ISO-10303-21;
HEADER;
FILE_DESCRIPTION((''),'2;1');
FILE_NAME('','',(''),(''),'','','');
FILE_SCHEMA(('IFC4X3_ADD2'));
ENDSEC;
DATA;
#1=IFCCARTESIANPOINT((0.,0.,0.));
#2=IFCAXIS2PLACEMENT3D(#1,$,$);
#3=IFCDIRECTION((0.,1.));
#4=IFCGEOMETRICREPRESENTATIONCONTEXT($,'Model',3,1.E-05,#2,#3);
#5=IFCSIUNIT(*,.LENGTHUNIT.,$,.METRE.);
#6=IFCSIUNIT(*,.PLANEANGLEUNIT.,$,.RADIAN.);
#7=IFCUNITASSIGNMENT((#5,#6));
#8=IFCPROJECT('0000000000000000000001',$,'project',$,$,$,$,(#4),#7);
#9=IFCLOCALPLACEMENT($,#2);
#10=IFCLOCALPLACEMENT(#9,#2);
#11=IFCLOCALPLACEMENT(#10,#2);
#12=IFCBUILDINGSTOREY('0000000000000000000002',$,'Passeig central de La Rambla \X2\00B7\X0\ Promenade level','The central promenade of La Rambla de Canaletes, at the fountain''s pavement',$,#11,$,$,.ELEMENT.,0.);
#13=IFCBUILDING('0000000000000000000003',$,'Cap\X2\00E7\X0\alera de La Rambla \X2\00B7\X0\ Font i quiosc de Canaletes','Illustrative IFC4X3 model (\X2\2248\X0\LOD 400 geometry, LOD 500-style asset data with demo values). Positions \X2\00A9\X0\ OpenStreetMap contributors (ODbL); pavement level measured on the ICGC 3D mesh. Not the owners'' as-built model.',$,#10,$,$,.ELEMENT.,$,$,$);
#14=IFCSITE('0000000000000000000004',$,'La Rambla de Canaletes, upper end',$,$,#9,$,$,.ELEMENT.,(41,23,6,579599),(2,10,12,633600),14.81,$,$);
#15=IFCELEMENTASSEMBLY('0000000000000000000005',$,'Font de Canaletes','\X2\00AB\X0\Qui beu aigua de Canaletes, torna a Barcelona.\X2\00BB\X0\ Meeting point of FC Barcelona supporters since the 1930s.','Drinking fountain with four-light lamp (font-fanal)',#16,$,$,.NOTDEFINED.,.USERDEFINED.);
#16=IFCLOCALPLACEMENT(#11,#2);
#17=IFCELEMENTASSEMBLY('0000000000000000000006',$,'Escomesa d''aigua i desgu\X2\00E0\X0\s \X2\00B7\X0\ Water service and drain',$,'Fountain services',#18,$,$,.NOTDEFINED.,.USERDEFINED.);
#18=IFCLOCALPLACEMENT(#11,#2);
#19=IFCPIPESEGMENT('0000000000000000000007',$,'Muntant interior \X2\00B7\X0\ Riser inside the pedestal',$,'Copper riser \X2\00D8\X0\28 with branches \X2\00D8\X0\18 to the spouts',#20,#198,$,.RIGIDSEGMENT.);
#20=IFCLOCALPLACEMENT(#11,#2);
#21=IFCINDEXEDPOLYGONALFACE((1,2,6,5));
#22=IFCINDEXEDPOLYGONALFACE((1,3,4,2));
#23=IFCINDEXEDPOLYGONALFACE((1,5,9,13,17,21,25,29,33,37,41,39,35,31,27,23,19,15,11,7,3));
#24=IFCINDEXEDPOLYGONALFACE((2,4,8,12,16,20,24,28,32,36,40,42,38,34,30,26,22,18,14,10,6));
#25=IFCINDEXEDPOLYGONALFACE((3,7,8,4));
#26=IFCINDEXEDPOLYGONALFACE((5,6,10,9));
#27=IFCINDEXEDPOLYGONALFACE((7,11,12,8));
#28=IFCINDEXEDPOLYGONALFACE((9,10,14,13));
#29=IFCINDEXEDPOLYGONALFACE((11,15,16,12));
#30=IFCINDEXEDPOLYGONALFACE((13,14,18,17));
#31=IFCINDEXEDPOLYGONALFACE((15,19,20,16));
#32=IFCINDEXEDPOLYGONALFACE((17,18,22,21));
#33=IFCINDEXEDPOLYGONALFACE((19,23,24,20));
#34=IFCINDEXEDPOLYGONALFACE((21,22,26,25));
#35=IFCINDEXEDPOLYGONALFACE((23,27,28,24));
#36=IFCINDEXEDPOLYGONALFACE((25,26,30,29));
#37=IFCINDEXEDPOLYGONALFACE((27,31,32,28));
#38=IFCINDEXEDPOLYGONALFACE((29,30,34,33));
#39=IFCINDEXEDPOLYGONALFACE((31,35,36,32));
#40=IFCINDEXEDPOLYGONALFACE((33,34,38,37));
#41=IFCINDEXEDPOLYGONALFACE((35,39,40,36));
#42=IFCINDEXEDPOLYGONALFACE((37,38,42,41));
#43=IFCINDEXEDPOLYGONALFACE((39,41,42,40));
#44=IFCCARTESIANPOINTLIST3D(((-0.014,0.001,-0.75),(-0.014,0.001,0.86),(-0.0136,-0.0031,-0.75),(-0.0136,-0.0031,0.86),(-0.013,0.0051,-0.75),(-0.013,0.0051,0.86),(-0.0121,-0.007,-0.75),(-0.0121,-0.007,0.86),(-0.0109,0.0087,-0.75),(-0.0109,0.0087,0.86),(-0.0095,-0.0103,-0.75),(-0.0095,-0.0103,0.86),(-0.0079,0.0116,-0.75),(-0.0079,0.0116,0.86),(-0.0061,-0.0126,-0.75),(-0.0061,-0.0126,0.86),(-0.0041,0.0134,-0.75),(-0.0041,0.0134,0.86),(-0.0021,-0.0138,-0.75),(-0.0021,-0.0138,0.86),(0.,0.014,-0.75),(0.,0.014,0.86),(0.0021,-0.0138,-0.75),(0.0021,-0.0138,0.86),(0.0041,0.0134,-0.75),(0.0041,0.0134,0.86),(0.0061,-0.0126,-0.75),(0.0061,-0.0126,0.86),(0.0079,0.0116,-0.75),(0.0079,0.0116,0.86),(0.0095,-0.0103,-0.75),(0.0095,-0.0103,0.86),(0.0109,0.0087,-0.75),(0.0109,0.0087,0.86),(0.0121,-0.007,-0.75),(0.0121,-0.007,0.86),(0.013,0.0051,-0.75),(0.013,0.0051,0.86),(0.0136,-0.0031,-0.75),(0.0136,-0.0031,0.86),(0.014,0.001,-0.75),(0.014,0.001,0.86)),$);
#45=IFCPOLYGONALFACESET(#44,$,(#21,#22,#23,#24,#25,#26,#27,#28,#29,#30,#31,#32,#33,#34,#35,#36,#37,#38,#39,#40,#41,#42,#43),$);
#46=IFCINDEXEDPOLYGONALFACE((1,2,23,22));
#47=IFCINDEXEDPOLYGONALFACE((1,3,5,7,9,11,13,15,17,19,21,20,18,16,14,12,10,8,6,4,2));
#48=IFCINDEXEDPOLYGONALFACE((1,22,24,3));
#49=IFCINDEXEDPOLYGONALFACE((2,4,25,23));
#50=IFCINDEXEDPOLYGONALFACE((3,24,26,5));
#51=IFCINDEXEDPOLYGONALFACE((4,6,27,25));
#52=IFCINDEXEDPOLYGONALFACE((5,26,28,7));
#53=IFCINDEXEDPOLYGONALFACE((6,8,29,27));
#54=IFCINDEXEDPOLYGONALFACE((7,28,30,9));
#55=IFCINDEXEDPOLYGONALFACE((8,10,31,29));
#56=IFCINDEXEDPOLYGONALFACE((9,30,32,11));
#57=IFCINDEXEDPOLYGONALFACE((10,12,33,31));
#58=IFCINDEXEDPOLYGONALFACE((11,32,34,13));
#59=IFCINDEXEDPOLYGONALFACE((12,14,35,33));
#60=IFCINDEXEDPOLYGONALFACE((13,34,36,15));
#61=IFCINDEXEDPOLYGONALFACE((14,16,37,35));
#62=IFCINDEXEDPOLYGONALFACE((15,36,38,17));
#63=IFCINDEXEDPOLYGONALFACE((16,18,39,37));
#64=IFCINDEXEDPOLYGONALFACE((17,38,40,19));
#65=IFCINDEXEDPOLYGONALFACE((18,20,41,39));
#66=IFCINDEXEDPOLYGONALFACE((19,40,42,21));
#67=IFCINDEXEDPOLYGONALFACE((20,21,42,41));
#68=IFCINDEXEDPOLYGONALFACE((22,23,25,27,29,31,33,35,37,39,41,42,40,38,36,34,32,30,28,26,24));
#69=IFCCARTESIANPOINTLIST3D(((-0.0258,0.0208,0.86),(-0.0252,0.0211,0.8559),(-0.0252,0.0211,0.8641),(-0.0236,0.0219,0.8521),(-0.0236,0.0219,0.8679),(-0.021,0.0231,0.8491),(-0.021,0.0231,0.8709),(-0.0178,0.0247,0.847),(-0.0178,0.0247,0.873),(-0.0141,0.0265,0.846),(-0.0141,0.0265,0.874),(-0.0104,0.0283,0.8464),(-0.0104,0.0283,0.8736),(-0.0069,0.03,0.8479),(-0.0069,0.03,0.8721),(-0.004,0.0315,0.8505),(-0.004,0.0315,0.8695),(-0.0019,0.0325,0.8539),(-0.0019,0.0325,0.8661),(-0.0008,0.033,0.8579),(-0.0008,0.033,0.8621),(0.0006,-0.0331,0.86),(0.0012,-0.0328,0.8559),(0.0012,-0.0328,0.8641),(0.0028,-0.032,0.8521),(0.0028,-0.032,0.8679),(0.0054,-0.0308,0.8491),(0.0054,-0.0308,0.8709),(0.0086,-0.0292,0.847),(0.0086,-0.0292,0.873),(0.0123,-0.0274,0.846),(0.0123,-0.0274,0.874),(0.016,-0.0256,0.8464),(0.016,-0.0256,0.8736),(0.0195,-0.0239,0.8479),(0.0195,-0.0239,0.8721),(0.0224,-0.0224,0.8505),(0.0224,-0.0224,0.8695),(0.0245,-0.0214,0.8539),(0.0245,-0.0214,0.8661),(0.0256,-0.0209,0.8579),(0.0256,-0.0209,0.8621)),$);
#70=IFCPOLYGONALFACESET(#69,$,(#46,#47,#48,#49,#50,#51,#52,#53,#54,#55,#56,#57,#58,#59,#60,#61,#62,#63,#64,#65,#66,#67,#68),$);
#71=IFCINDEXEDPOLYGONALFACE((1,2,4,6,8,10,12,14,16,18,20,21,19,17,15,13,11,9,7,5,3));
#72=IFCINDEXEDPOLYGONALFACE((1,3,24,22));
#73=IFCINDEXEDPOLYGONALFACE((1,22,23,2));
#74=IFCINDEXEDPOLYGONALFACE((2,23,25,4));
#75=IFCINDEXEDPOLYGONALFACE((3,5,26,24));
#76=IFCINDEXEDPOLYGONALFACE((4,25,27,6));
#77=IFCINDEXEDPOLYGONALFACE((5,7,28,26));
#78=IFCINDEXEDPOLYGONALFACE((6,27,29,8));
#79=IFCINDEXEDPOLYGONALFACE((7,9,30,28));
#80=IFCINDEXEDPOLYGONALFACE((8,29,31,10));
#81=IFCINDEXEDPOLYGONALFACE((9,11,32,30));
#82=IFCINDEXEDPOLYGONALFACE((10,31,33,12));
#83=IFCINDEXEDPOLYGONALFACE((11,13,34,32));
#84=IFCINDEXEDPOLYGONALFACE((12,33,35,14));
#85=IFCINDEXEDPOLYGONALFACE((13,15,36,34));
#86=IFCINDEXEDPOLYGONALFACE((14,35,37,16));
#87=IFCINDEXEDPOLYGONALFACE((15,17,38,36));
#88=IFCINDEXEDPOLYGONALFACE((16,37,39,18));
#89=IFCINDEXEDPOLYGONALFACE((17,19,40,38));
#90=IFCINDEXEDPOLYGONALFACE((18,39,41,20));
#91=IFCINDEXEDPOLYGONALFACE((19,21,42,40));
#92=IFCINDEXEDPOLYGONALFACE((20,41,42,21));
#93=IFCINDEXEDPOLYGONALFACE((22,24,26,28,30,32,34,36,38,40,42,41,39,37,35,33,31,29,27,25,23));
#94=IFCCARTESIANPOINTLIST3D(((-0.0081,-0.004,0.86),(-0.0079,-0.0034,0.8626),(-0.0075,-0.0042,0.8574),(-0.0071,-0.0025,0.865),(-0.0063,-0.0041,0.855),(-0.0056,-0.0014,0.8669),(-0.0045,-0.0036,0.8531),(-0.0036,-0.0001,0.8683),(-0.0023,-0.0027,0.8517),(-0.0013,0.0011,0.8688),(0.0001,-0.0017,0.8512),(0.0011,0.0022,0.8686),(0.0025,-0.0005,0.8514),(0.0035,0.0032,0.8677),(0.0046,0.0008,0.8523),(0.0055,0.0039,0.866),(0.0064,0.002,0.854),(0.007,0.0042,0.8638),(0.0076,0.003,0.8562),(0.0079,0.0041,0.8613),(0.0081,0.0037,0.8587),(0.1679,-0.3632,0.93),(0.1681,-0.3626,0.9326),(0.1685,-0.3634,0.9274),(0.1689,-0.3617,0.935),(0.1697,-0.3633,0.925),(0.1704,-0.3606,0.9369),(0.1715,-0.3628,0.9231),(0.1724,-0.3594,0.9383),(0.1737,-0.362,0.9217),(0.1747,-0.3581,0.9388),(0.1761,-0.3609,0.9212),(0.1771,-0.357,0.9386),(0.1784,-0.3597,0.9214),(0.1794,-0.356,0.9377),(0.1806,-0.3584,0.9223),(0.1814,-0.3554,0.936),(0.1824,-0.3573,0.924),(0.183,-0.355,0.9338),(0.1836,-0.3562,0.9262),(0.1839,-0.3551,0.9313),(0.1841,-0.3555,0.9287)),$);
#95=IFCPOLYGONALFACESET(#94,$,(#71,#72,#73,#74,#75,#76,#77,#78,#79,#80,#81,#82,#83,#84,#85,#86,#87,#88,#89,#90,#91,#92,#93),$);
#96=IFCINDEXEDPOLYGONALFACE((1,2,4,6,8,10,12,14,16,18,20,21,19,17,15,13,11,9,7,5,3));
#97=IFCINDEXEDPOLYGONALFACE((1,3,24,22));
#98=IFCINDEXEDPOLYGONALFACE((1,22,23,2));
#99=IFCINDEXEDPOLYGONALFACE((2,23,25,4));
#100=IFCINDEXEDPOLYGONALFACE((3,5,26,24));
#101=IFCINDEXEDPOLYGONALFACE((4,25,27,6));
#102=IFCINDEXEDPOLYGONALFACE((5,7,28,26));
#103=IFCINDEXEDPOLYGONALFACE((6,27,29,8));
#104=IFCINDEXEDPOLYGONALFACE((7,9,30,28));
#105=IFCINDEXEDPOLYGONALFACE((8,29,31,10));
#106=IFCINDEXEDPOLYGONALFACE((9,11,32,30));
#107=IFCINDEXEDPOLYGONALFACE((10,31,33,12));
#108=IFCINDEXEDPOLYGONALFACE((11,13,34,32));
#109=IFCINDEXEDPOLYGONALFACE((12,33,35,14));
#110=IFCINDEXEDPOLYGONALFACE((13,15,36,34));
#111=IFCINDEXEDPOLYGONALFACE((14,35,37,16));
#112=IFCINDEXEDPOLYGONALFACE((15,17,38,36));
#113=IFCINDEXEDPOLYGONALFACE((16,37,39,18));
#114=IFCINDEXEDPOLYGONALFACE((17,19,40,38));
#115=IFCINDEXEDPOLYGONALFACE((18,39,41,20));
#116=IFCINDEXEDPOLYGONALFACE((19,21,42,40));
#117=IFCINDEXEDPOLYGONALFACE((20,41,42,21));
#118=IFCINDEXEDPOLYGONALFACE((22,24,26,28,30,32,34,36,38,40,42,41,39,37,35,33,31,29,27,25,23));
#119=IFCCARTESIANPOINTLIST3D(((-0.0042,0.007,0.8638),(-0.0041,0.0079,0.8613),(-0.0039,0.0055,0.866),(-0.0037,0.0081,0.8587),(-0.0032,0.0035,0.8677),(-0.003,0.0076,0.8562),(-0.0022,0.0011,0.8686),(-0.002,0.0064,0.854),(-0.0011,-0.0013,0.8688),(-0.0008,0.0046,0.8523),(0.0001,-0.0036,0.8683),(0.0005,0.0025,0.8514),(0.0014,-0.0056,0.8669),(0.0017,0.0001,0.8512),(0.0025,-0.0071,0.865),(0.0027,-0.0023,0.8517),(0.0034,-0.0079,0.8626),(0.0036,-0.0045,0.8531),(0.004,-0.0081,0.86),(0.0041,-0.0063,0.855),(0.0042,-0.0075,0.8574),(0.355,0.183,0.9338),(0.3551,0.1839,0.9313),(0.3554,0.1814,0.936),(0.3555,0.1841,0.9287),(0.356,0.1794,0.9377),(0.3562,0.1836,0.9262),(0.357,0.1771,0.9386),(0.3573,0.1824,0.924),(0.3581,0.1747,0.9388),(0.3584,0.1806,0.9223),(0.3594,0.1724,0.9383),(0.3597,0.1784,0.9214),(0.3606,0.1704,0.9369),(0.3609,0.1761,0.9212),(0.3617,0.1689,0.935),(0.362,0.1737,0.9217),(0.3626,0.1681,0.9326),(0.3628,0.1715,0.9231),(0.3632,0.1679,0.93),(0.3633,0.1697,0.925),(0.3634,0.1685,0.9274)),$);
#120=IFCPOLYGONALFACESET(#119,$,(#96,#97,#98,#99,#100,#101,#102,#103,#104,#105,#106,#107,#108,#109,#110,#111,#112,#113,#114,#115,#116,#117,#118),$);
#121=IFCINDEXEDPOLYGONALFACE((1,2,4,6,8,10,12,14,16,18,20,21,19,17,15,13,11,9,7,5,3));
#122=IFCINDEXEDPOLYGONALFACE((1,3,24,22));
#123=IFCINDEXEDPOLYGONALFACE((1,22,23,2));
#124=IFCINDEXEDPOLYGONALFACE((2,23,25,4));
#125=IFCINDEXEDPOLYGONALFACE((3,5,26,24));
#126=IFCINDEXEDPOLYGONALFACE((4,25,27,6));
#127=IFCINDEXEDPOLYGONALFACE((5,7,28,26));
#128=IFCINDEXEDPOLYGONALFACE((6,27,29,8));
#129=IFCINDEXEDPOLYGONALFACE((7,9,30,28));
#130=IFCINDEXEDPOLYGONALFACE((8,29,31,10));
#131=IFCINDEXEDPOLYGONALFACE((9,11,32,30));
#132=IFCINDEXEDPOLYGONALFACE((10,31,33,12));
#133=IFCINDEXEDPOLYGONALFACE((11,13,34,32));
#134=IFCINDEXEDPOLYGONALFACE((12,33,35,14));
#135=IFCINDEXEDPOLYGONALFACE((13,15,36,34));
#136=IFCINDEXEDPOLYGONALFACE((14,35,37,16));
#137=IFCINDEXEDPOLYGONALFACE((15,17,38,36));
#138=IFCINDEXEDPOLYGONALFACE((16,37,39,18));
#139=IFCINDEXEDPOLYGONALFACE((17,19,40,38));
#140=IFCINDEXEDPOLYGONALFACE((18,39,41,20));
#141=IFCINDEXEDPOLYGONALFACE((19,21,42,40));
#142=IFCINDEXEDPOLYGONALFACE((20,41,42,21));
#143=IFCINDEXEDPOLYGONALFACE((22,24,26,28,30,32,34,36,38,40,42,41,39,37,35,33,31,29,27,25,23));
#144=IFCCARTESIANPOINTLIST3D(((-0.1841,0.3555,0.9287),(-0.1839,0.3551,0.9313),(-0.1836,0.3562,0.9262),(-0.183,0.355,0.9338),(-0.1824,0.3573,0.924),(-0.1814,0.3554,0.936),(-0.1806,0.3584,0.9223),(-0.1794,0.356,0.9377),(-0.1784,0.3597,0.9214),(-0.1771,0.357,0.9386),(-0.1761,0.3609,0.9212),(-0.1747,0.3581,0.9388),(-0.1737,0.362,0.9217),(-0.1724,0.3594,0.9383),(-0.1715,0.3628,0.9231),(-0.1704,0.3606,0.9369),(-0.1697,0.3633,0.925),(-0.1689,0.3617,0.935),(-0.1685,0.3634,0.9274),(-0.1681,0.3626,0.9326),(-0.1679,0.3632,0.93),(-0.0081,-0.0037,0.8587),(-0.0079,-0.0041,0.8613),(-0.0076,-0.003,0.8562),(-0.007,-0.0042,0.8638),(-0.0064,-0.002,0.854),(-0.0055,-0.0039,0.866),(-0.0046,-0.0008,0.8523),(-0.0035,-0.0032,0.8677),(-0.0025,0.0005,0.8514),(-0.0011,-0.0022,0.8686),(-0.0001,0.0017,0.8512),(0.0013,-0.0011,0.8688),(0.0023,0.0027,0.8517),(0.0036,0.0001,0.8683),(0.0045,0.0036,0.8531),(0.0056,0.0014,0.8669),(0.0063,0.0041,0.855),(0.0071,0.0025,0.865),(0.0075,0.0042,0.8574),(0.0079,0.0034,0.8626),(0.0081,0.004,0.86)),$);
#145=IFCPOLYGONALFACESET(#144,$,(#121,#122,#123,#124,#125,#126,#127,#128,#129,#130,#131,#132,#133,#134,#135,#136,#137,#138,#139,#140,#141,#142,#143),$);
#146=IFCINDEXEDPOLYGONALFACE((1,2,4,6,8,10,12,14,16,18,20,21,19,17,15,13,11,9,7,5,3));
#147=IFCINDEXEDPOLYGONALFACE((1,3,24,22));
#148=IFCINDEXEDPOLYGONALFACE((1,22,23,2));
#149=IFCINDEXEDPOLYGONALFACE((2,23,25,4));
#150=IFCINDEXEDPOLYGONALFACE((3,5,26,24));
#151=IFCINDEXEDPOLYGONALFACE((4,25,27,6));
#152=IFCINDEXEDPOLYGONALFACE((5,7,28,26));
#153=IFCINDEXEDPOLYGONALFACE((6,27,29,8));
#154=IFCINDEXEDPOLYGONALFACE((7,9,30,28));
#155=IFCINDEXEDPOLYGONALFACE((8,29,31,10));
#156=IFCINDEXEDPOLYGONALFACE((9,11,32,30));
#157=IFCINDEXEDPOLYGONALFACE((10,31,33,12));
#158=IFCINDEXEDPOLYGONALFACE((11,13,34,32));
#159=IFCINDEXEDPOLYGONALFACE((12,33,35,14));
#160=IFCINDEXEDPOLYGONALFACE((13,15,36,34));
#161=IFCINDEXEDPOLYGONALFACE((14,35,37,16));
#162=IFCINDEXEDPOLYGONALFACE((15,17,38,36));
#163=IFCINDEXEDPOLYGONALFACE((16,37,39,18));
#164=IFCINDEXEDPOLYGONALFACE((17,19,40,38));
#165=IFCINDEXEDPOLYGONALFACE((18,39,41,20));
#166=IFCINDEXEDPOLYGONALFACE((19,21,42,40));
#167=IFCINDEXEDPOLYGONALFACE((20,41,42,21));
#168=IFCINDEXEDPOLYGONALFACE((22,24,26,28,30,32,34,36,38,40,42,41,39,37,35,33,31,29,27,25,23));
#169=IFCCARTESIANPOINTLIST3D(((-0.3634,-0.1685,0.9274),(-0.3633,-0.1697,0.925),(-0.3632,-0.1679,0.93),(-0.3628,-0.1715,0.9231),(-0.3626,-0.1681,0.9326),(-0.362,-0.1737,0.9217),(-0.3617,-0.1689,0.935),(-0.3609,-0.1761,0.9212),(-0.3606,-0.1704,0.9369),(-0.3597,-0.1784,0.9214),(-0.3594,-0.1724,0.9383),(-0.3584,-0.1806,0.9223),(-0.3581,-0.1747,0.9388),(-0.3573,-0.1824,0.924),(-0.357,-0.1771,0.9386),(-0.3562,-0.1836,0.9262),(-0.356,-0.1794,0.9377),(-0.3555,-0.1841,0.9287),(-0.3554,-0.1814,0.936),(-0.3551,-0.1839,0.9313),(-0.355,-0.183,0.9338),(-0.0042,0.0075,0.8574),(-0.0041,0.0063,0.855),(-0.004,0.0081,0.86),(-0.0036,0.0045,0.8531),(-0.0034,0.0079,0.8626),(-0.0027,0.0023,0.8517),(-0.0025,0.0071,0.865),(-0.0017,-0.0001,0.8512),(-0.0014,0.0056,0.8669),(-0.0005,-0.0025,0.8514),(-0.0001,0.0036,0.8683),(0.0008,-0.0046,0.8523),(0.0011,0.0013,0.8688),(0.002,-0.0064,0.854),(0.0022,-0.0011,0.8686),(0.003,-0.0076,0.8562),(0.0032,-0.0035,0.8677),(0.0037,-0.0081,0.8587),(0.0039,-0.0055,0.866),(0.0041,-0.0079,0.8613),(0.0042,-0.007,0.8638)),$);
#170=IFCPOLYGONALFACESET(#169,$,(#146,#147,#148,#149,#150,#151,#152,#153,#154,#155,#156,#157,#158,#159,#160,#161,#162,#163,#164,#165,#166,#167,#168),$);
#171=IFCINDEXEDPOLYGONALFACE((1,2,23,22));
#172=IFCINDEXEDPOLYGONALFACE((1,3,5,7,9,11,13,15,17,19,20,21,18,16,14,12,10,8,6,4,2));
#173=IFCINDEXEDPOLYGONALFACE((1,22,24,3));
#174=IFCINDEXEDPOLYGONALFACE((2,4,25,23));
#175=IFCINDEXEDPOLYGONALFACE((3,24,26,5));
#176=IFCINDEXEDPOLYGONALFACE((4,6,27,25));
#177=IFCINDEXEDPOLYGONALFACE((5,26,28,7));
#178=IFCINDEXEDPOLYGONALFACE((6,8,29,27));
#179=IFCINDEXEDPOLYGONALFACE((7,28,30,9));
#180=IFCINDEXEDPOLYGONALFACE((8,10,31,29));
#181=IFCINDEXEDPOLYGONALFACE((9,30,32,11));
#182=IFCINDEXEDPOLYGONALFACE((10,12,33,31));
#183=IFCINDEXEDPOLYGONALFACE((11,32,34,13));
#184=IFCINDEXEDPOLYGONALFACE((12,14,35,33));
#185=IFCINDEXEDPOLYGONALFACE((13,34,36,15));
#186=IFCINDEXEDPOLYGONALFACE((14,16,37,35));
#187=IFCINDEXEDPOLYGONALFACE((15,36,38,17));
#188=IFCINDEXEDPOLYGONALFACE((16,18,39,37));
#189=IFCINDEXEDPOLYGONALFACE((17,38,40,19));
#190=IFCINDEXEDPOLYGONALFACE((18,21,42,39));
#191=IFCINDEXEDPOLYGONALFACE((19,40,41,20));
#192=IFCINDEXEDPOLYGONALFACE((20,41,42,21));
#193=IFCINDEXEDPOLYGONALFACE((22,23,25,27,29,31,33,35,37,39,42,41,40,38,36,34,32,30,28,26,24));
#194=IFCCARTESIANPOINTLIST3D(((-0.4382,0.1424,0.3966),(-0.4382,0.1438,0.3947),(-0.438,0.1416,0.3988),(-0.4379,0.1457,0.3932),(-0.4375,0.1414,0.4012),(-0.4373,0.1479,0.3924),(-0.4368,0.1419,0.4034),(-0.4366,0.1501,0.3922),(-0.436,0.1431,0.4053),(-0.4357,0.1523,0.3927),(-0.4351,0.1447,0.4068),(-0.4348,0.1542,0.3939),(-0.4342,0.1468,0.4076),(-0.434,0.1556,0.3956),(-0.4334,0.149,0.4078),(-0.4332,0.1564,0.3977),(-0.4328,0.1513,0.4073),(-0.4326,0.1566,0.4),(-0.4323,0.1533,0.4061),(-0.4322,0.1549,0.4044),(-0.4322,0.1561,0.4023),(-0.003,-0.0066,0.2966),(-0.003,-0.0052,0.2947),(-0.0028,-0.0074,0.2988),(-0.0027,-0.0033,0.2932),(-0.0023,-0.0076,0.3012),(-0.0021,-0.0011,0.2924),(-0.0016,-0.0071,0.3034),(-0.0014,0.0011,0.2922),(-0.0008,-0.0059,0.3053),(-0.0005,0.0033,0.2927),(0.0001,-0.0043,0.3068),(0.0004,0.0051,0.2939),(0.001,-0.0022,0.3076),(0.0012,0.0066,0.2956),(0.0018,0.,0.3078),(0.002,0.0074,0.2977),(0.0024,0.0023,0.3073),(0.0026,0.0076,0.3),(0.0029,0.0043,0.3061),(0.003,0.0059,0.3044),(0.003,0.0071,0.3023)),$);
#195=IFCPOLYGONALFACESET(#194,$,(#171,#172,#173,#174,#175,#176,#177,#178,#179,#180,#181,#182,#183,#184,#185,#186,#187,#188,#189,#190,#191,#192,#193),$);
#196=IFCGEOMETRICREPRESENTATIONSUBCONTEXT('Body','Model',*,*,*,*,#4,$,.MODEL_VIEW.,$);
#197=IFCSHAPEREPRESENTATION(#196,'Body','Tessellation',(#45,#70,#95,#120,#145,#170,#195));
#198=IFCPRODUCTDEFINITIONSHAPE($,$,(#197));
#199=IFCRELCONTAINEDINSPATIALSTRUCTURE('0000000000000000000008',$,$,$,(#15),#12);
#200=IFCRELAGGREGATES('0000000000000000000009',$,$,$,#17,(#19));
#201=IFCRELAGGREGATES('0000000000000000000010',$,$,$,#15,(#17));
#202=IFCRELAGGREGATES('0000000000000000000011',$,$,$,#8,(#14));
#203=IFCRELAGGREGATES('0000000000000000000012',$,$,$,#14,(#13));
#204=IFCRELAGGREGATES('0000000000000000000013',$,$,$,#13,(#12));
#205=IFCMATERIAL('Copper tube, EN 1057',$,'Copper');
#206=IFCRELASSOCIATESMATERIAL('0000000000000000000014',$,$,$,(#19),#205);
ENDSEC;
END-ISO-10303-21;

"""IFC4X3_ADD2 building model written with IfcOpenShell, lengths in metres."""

from ifc_helpers import new_model, si_unit, direction, frame, origin, origin_2d_with_axis, place, context, subcontext, project, spatial, circle, extrude, material, element, aggregate, save


model = new_model("IFC4X3_ADD2")

# Units and contexts
model_context = context("Model", 3, precision=1e-05, world=origin(), true_north=direction((0.0, 1.0)))
body_context = subcontext(model_context, "Body", "Model", "MODEL_VIEW")
ifc_project = project(units=[si_unit("LENGTHUNIT", "METRE"), si_unit("PLANEANGLEUNIT", "RADIAN")], contexts=[model_context])

# Site, building, storey
site_placement = place(None, origin())
site = spatial("IfcSite", under=ifc_project, at=site_placement, Name="La Rambla de Canaletes, upper end", CompositionType="ELEMENT", RefLatitude=(41, 23, 6, 579599), RefLongitude=(2, 10, 12, 633600), RefElevation=14.81)
building_placement = place(site_placement, origin())
building = spatial("IfcBuilding", under=site, at=building_placement, Name="Capçalera de La Rambla · Font i quiosc de Canaletes", Description="Illustrative IFC4X3 model (≈LOD 400 geometry, LOD 500-style asset data with demo values). Positions © OpenStreetMap contributors (ODbL); pavement level measured on the ICGC 3D mesh. Not the owners' as-built model.", CompositionType="ELEMENT")
storey_placement = place(building_placement, origin())
storey = spatial("IfcBuildingStorey", under=building, at=storey_placement, Name="Passeig central de La Rambla · Promenade level", Description="The central promenade of La Rambla de Canaletes, at the fountain's pavement", CompositionType="ELEMENT", Elevation=0.0)

# Element assemblies, pipe segment
assembly_1_placement = place(building_placement, origin())
assembly_1 = element("IfcElementAssembly", 1, at=assembly_1_placement, inside=storey, Name="Font de Canaletes", Description="«Qui beu aigua de Canaletes, torna a Barcelona.» Meeting point of FC Barcelona supporters since the 1930s.", ObjectType="Drinking fountain with four-light lamp (font-fanal)", AssemblyPlace="NOTDEFINED", PredefinedType="USERDEFINED")
assembly_2_placement = place(building_placement, origin())
assembly_2 = element("IfcElementAssembly", 2, at=assembly_2_placement, Name="Escomesa d'aigua i desguàs · Water service and drain", ObjectType="Fountain services", AssemblyPlace="NOTDEFINED", PredefinedType="USERDEFINED")
ifc_material_1 = material(Name="Copper tube, EN 1057", Category="Copper")
pipe_segment_1_placement = place(building_placement, origin())
pipe_segment_1 = element("IfcPipeSegment", 3, at=pipe_segment_1_placement, material=ifc_material_1, Name="Muntant interior · Riser inside the pedestal", ObjectType="Copper riser Ø28 with branches Ø18 to the spouts", PredefinedType="RIGIDSEGMENT", context=body_context, shape_type="SweptSolid", body=[
    extrude(circle(Radius=0.014, at=origin_2d_with_axis()), frame((0.0, 0.0, -0.75), z_axis=(0.0, 0.0, 1.0), x_axis=(0.0, 1.0, 0.0)), (0.0, 0.0, 1.0), 1.61),
    extrude(circle(Radius=0.014, at=origin_2d_with_axis()), frame((-0.0132, 0.0269, 0.86), z_axis=(0.439939, -0.898028, 0.0), x_axis=(-0.898028, -0.439939, 0.0)), (0.0, 0.0, 1.0), 0.06),
    extrude(circle(Radius=0.009, at=origin_2d_with_axis()), frame((0.0, 0.0, 0.86), z_axis=(0.433353, -0.884585, 0.17238), x_axis=(-0.898028, -0.439939, 0.0)), (0.0, 0.0, 1.0), 0.4061),
    extrude(circle(Radius=0.009, at=origin_2d_with_axis()), frame((0.0, 0.0, 0.86), z_axis=(0.884585, 0.433353, 0.17238), x_axis=(0.439939, -0.898028, 0.0)), (0.0, 0.0, 1.0), 0.4061),
    extrude(circle(Radius=0.009, at=origin_2d_with_axis()), frame((0.0, 0.0, 0.86), z_axis=(-0.433353, 0.884585, 0.17238), x_axis=(0.898028, 0.439939, 0.0)), (0.0, 0.0, 1.0), 0.4061),
    extrude(circle(Radius=0.009, at=origin_2d_with_axis()), frame((0.0, 0.0, 0.86), z_axis=(-0.884585, -0.433353, 0.17238), x_axis=(-0.439939, 0.898028, 0.0)), (0.0, 0.0, 1.0), 0.4061),
    extrude(circle(Radius=0.008, at=origin_2d_with_axis()), frame((0.0, 0.0, 0.3), z_axis=(-0.924492, 0.316524, 0.21243), x_axis=(0.323917, 0.946085, 0.0)), (0.0, 0.0, 1.0), 0.4707),
])
aggregate(assembly_2, [pipe_segment_1])
aggregate(assembly_1, [assembly_2])

save(model, "model.ifc")
